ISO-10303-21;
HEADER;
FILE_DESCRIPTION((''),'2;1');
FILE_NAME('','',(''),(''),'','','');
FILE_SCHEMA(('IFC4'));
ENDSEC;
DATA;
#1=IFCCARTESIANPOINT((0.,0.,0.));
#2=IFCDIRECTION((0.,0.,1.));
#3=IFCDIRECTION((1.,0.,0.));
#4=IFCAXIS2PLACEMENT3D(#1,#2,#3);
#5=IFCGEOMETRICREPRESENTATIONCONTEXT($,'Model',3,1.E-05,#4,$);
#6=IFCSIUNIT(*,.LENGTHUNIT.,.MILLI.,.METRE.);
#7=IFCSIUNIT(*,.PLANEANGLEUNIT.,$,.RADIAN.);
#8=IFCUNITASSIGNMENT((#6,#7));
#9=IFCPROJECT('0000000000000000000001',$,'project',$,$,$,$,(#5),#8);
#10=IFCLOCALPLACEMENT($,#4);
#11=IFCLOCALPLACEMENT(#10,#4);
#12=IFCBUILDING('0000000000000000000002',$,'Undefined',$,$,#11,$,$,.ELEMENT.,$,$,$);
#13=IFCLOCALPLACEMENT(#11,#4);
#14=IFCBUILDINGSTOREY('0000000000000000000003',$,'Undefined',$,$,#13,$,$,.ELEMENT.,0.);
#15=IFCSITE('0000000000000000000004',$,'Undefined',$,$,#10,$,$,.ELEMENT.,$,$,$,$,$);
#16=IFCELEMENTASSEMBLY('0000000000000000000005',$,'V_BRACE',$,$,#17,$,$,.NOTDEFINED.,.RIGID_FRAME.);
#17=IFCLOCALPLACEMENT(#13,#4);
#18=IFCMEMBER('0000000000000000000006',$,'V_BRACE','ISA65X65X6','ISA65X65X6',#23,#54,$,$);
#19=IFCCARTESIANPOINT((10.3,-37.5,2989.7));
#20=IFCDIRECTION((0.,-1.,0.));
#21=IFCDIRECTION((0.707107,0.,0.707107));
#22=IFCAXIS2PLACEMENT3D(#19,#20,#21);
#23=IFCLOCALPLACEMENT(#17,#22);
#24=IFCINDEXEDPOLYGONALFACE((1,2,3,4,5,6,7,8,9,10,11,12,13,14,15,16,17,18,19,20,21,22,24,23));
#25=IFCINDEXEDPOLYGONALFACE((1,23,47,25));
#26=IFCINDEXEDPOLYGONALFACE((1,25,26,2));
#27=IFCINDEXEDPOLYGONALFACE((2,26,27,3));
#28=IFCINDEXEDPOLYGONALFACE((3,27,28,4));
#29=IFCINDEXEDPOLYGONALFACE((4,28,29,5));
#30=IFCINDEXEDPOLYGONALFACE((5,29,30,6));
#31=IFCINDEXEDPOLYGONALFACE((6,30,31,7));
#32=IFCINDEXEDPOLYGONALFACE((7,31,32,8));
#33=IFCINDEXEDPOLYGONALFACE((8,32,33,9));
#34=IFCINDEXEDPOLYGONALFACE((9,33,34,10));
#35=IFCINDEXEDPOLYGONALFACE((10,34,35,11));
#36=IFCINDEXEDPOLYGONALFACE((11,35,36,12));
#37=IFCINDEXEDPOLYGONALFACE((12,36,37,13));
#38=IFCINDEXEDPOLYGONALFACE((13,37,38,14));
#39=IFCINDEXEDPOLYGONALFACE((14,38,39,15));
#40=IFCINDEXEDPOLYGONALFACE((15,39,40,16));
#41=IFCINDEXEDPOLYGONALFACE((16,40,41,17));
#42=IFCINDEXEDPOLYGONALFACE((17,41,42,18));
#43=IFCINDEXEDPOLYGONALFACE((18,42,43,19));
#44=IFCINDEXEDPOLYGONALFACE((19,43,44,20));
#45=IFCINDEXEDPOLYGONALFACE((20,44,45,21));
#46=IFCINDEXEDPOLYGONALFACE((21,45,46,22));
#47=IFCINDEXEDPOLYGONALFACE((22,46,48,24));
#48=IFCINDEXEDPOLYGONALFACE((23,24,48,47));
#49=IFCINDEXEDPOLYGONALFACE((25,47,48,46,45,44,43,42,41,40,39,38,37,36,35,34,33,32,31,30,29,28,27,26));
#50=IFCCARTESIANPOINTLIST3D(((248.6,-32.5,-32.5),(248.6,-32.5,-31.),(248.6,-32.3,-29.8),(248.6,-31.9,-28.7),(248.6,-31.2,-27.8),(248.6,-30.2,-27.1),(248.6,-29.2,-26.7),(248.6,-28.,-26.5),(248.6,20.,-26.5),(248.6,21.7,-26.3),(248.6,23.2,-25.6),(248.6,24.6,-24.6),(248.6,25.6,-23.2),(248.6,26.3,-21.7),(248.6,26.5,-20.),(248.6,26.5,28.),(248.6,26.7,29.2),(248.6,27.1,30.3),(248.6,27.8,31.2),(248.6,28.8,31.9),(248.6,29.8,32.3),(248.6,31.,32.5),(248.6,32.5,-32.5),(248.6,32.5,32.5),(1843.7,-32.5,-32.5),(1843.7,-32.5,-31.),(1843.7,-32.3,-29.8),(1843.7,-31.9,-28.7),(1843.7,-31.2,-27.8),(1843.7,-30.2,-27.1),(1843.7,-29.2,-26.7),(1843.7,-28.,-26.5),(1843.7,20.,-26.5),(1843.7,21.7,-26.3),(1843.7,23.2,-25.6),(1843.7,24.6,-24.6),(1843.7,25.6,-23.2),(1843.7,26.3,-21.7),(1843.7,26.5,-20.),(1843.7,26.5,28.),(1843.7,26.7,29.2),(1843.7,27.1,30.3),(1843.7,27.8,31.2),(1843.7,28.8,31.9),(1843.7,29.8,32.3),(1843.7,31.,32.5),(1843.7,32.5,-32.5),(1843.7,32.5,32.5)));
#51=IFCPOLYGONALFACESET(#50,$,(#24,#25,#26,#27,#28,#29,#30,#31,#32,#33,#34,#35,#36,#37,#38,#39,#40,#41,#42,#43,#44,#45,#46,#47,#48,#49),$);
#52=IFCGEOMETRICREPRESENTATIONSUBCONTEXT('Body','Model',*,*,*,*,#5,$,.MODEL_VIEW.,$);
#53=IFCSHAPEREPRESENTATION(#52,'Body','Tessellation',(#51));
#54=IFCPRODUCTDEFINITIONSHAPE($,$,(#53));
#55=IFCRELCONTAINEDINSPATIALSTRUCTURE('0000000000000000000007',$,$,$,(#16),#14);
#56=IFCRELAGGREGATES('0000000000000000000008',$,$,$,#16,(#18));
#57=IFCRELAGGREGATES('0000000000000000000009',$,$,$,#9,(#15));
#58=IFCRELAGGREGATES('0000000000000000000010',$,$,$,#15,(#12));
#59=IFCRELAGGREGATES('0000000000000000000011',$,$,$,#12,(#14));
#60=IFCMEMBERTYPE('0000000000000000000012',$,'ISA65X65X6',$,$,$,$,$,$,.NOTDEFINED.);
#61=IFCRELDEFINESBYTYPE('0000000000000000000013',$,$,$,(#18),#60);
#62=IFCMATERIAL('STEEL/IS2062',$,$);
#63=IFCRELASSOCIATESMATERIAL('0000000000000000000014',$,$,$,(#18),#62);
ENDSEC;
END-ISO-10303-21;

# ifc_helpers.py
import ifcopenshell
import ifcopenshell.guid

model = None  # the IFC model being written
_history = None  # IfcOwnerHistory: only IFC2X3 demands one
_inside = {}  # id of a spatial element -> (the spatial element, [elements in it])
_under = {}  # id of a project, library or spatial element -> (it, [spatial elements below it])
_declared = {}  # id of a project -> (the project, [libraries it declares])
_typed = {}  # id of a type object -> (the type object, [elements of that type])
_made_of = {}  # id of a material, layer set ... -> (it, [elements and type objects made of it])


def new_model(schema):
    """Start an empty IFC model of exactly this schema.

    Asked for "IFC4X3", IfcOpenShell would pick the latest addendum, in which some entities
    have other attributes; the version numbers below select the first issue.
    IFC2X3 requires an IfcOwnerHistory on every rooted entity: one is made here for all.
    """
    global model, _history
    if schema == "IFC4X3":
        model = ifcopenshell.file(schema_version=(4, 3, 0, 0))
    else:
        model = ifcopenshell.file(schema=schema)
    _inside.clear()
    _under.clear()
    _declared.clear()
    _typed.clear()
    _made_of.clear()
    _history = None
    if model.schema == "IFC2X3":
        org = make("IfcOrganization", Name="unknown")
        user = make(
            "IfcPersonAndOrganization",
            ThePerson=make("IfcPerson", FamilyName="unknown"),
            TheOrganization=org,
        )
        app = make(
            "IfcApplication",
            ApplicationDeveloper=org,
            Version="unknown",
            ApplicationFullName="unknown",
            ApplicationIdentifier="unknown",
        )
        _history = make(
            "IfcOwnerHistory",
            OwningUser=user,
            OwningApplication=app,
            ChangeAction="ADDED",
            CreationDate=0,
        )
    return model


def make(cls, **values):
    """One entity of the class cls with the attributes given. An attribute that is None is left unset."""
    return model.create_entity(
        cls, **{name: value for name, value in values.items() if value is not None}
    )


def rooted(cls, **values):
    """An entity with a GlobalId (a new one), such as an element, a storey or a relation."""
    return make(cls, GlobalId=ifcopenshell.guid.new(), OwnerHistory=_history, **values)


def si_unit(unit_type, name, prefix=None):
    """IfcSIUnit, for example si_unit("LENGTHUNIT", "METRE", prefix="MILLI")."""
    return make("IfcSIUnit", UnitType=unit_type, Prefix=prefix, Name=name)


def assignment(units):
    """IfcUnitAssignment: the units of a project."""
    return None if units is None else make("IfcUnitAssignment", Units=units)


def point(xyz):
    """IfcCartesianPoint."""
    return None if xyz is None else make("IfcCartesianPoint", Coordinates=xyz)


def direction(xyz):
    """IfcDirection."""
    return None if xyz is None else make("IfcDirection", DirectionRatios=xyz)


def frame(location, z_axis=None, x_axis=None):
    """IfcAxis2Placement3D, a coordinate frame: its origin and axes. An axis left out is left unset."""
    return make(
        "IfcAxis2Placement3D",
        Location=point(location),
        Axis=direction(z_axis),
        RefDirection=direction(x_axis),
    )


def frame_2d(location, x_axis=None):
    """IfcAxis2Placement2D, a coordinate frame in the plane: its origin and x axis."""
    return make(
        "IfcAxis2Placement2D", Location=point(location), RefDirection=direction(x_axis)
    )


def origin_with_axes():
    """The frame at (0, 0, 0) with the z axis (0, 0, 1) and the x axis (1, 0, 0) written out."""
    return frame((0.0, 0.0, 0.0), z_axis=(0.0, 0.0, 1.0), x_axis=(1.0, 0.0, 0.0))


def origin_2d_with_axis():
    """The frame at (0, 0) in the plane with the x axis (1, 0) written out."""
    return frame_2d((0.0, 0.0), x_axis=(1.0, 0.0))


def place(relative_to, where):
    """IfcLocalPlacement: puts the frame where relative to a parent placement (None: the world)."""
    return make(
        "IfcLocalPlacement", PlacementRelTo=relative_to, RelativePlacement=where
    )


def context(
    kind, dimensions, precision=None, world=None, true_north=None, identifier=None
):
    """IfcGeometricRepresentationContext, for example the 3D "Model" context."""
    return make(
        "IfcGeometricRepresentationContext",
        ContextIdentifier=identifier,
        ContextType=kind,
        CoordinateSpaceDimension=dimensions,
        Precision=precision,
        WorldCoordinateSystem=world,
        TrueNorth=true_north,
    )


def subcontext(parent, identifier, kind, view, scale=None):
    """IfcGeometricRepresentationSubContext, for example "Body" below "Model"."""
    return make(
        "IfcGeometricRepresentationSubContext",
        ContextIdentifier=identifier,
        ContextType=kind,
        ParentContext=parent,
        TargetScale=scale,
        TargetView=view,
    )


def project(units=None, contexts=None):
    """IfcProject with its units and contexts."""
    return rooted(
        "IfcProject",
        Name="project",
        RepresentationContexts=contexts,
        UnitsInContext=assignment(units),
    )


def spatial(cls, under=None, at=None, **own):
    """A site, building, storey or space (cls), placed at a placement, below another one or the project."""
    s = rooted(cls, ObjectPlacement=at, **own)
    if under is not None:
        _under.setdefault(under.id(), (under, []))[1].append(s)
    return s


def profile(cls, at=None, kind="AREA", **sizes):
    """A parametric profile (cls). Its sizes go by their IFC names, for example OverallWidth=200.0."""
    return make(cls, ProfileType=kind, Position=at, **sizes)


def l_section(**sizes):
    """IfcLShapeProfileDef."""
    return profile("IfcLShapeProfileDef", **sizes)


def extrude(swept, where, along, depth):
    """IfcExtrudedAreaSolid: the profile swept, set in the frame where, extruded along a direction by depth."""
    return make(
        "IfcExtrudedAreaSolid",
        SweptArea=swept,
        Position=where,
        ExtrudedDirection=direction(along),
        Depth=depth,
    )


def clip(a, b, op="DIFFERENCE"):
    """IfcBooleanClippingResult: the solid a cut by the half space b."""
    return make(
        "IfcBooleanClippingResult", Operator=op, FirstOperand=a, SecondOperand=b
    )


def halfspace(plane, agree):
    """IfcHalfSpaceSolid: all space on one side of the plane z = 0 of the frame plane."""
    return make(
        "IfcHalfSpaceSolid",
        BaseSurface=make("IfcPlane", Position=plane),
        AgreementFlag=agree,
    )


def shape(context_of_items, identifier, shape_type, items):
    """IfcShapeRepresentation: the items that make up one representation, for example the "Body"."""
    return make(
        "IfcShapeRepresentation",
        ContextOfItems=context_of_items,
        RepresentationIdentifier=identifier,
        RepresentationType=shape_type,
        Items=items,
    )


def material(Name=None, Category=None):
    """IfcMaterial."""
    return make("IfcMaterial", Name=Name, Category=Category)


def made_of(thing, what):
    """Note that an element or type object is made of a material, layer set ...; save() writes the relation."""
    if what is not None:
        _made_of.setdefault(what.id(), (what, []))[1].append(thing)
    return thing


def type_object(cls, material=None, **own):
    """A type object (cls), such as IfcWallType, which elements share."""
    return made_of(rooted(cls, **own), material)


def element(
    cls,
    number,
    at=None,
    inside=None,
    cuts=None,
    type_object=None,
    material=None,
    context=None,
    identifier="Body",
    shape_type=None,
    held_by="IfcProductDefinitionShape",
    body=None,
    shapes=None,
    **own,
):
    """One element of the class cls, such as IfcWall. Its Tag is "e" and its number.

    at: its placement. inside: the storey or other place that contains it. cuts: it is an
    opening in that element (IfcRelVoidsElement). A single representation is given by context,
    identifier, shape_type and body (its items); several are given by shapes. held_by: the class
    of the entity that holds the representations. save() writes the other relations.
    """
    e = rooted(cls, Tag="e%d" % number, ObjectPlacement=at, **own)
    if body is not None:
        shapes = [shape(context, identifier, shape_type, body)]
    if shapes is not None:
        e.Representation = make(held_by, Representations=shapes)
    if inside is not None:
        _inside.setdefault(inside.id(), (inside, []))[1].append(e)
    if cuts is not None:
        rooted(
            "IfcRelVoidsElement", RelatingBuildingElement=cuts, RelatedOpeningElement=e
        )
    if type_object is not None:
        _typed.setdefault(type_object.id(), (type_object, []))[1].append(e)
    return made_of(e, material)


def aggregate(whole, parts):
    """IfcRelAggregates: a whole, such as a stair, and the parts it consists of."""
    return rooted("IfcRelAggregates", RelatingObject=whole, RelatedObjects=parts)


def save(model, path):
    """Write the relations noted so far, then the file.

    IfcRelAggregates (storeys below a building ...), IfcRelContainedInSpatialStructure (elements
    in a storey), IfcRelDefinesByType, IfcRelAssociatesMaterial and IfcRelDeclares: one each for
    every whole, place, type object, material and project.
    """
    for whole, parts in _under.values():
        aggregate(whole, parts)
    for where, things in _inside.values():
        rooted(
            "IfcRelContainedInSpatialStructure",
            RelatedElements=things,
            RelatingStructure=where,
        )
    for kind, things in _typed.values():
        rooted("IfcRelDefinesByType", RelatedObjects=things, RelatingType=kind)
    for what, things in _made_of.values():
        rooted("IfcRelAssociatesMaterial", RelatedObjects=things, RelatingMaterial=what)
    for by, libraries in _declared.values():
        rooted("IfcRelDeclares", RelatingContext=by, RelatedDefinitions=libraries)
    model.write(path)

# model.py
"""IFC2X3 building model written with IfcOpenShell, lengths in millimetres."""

from ifc_helpers import new_model, si_unit, frame, origin_with_axes, origin_2d_with_axis, place, context, subcontext, project, spatial, l_section, extrude, clip, halfspace, material, type_object, element, aggregate, save


model = new_model("IFC2X3")

# Units and contexts
model_context = context("Model", 3, precision=1e-05, world=origin_with_axes())
body_context = subcontext(model_context, "Body", "Model", "MODEL_VIEW")
ifc_project = project(units=[si_unit("LENGTHUNIT", "METRE", prefix="MILLI"), si_unit("PLANEANGLEUNIT", "RADIAN")], contexts=[model_context])

# Site, building, storey
site_placement = place(None, origin_with_axes())
site = spatial("IfcSite", under=ifc_project, at=site_placement, Name="Undefined", CompositionType="ELEMENT")
building_placement = place(site_placement, origin_with_axes())
building = spatial("IfcBuilding", under=site, at=building_placement, Name="Undefined", CompositionType="ELEMENT")
storey_placement = place(building_placement, origin_with_axes())
storey = spatial("IfcBuildingStorey", under=building, at=storey_placement, Name="Undefined", CompositionType="ELEMENT", Elevation=0.0)

# Shared definitions
ifc_material = material(Name="STEEL/IS2062")

# Element assembly, member
member_type = type_object("IfcMemberType", Name="ISA65X65X6", PredefinedType="NOTDEFINED")
assembly_1_placement = place(storey_placement, origin_with_axes())
assembly_1 = element("IfcElementAssembly", 1, at=assembly_1_placement, inside=storey, Name="V_BRACE", AssemblyPlace="NOTDEFINED", PredefinedType="RIGID_FRAME")
member_1_placement = place(assembly_1_placement, frame((10.3, -37.5, 2989.7), z_axis=(0.0, -1.0, 0.0), x_axis=(0.707107, 0.0, 0.707107)))
member_1 = element("IfcMember", 2, at=member_1_placement, type_object=member_type, material=ifc_material, Name="V_BRACE", Description="ISA65X65X6", ObjectType="ISA65X65X6", context=body_context, shape_type="Clipping", body=[
    clip(clip(extrude(l_section(Depth=65.0, Width=65.0, Thickness=6.0, FilletRadius=6.5, EdgeRadius=4.5, at=origin_2d_with_axis()), frame((2121.3, 0.0, 0.0), z_axis=(-1.0, 0.0, 0.0), x_axis=(0.0, -1.0, 0.0)), (0.0, 0.0, 1.0), 2121.3), halfspace(frame((1843.7, 0.0, -32.5), z_axis=(-1.0, 0.0, 0.0), x_axis=(0.0, -1.0, 0.0)), True)), halfspace(frame((248.6, 0.0, -32.5), z_axis=(1.0, 0.0, 0.0), x_axis=(0.0, 1.0, 0.0)), True)),
])
aggregate(assembly_1, [member_1])

save(model, "model.ifc")
